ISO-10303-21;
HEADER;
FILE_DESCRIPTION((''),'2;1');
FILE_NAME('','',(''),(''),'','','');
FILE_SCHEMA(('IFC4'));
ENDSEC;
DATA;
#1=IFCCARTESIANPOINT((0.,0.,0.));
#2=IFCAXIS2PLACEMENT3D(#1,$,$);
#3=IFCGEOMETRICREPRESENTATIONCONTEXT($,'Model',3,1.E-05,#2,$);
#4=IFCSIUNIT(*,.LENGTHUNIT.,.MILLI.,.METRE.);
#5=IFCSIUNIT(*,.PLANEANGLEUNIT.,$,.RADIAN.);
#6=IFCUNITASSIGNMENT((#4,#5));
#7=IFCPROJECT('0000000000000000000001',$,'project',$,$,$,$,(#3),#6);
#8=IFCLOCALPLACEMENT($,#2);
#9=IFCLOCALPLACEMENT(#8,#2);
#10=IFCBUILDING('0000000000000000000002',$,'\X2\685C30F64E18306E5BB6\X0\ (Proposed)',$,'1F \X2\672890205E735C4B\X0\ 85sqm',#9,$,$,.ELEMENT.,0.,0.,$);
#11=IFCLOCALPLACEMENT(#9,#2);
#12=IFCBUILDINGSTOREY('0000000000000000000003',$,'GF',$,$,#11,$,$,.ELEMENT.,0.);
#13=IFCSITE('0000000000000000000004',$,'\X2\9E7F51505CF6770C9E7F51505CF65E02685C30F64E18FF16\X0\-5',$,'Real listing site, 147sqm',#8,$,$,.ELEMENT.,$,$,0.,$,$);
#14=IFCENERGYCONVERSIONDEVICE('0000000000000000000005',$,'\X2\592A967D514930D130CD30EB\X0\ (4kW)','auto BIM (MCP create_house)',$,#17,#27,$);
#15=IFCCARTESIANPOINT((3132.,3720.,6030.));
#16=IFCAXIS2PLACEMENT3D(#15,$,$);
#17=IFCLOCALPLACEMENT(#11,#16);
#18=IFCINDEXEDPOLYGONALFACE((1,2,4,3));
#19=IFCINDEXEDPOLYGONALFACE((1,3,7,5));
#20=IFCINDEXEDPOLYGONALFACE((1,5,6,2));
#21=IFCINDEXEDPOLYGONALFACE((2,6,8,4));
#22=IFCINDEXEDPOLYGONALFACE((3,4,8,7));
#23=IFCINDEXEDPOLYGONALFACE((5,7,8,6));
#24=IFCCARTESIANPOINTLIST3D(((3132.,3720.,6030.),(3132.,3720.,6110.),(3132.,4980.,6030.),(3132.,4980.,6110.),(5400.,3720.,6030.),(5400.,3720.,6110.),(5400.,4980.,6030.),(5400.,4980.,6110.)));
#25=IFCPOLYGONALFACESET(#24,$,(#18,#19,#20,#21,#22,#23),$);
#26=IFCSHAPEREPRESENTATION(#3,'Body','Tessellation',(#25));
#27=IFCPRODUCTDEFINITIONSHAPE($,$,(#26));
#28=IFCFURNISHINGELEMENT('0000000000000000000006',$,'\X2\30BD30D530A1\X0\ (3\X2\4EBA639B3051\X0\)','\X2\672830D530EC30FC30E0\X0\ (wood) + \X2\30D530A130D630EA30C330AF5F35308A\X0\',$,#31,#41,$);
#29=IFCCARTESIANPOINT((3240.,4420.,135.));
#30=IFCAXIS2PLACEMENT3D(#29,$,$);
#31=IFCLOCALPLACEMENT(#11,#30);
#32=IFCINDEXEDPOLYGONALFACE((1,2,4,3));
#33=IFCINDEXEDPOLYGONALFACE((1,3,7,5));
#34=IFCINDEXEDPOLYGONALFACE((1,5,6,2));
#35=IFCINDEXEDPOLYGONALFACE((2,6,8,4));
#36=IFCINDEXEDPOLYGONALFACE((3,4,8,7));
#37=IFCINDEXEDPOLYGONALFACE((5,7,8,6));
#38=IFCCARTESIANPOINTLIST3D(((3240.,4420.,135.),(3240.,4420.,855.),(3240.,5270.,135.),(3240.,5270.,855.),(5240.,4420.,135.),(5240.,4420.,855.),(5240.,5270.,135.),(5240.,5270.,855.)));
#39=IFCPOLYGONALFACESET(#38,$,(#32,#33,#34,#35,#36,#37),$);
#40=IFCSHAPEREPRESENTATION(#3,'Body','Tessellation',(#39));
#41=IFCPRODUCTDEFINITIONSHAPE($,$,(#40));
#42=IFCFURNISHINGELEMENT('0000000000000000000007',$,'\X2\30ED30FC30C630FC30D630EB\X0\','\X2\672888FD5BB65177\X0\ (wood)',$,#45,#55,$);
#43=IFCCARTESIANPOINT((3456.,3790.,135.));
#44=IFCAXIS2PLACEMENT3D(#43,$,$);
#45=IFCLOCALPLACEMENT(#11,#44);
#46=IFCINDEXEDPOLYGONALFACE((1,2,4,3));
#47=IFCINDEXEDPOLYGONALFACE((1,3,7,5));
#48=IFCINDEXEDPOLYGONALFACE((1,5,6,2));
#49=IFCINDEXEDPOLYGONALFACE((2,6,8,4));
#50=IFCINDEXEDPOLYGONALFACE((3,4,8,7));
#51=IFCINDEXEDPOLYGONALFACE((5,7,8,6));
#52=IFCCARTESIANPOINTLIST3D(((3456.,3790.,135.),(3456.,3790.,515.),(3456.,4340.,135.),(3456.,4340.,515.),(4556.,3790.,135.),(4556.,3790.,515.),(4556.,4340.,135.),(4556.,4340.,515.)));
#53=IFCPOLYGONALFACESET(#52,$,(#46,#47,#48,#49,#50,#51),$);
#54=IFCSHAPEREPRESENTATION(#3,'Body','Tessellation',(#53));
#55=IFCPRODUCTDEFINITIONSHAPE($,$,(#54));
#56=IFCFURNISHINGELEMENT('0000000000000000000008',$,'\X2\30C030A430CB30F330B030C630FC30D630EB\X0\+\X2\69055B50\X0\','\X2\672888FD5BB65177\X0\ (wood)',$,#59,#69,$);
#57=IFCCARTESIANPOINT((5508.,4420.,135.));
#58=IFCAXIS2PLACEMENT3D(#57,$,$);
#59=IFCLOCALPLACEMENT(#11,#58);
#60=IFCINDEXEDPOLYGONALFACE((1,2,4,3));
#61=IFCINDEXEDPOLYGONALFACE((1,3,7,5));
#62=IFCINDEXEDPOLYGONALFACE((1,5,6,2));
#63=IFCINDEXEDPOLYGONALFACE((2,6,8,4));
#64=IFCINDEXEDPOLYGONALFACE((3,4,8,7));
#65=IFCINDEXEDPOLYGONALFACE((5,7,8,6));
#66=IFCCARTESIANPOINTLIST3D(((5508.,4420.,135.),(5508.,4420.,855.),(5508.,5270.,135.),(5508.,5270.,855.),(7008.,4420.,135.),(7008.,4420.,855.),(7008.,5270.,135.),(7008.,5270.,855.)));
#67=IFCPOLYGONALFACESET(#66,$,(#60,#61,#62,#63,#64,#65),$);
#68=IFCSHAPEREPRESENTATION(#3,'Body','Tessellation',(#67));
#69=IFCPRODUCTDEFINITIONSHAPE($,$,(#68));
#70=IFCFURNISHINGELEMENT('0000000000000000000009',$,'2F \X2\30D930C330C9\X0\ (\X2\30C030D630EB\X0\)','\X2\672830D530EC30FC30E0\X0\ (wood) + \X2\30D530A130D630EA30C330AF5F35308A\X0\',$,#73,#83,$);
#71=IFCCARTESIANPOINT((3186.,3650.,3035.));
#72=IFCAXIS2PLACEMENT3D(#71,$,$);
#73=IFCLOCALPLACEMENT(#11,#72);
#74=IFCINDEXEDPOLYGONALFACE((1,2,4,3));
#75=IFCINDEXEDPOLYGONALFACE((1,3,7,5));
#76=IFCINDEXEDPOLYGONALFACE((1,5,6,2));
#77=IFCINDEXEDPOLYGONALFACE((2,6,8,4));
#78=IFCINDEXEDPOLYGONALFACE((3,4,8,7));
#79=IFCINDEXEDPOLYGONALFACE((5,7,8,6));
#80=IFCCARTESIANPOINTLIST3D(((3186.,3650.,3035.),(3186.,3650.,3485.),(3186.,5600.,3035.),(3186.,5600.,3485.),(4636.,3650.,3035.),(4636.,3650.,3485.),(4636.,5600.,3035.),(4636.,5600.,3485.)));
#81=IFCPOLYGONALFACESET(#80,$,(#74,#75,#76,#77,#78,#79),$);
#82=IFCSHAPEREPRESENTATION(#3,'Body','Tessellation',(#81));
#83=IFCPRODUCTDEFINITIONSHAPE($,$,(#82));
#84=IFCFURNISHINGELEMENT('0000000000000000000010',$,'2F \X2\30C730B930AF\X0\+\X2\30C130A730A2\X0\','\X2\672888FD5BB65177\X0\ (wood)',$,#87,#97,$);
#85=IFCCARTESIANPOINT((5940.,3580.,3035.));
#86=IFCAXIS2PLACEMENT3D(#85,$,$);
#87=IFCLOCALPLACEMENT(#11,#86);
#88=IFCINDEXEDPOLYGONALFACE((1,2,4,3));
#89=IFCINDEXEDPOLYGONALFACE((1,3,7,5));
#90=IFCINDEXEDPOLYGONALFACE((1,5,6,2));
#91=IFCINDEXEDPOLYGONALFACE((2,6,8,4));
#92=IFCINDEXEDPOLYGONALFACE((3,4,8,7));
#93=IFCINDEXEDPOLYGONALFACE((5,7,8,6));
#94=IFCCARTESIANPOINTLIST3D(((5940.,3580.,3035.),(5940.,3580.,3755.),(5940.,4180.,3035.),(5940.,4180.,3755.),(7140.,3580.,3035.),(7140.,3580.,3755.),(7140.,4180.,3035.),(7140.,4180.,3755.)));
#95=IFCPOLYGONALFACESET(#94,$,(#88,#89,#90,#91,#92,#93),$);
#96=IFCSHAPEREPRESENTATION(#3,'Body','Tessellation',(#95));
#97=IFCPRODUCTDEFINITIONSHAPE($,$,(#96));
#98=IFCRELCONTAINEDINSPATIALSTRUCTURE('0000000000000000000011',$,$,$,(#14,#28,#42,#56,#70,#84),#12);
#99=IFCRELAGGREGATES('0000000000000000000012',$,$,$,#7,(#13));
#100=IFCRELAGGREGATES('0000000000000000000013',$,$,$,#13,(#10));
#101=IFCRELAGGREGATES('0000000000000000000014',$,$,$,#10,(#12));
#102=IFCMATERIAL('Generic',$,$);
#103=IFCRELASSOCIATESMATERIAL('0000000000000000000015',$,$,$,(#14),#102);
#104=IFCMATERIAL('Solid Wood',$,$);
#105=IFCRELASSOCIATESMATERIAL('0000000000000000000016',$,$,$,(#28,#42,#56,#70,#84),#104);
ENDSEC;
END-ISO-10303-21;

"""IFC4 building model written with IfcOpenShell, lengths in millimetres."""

from ifc_helpers import new_model, si_unit, frame, frame_2d, origin, place, context, project, spatial, rectangle, extrude, material, element, save


model = new_model("IFC4")

# Units and contexts
model_context = context("Model", 3, precision=1e-05, world=origin())
ifc_project = project(units=[si_unit("LENGTHUNIT", "METRE", prefix="MILLI"), si_unit("PLANEANGLEUNIT", "RADIAN")], contexts=[model_context])

# Site, building, storey
site_placement = place(None, origin())
site = spatial("IfcSite", under=ifc_project, at=site_placement, Name="鹿児島県鹿児島市桜ヶ丘６-5", ObjectType="Real listing site, 147sqm", CompositionType="ELEMENT", RefElevation=0.0)
building_placement = place(site_placement, origin())
building = spatial("IfcBuilding", under=site, at=building_placement, Name="桜ヶ丘の家 (Proposed)", ObjectType="1F 木造平屋 85sqm", CompositionType="ELEMENT", ElevationOfRefHeight=0.0, ElevationOfTerrain=0.0)
storey_placement = place(building_placement, origin())
storey = spatial("IfcBuildingStorey", under=building, at=storey_placement, Name="GF", CompositionType="ELEMENT", Elevation=0.0)

# Shared definitions
ifc_material_1 = material(Name="Solid Wood")

# Shared definitions
ifc_material_2 = material(Name="Generic")

# Energy conversion device
energy_conversion_device_placement = place(storey_placement, frame((3132.0, 3720.0, 6030.0)))
element("IfcEnergyConversionDevice", 1, at=energy_conversion_device_placement, inside=storey, material=ifc_material_2, Name="太陽光パネル (4kW)", Description="auto BIM (MCP create_house)", context=model_context, shape_type="SweptSolid", body=[
    extrude(rectangle(XDim=2268.0, YDim=1260.0, at=frame_2d((1134.0, 630.0))), frame((3132.0, 3720.0, 6030.0)), (0.0, 0.0, 1.0), 80.0),
])

# Furnishing elements
furnishing_1_placement = place(storey_placement, frame((3240.0, 4420.0, 135.0)))
element("IfcFurnishingElement", 2, at=furnishing_1_placement, inside=storey, material=ifc_material_1, Name="ソファ (3人掛け)", Description="木フレーム (wood) + ファブリック張り", context=model_context, shape_type="SweptSolid", body=[
    extrude(rectangle(XDim=2000.0, YDim=850.0, at=frame_2d((1000.0, 425.0))), frame((3240.0, 4420.0, 135.0)), (0.0, 0.0, 1.0), 720.0),
])
furnishing_2_placement = place(storey_placement, frame((3456.0, 3790.0, 135.0)))
element("IfcFurnishingElement", 3, at=furnishing_2_placement, inside=storey, material=ifc_material_1, Name="ローテーブル", Description="木製家具 (wood)", context=model_context, shape_type="SweptSolid", body=[
    extrude(rectangle(XDim=1100.0, YDim=550.0, at=frame_2d((550.0, 275.0))), frame((3456.0, 3790.0, 135.0)), (0.0, 0.0, 1.0), 380.0),
])
furnishing_3_placement = place(storey_placement, frame((5508.0, 4420.0, 135.0)))
element("IfcFurnishingElement", 4, at=furnishing_3_placement, inside=storey, material=ifc_material_1, Name="ダイニングテーブル+椅子", Description="木製家具 (wood)", context=model_context, shape_type="SweptSolid", body=[
    extrude(rectangle(XDim=1500.0, YDim=850.0, at=frame_2d((750.0, 425.0))), frame((5508.0, 4420.0, 135.0)), (0.0, 0.0, 1.0), 720.0),
])
furnishing_4_placement = place(storey_placement, frame((3186.0, 3650.0, 3035.0)))
element("IfcFurnishingElement", 5, at=furnishing_4_placement, inside=storey, material=ifc_material_1, Name="2F ベッド (ダブル)", Description="木フレーム (wood) + ファブリック張り", context=model_context, shape_type="SweptSolid", body=[
    extrude(rectangle(XDim=1450.0, YDim=1950.0, at=frame_2d((725.0, 975.0))), frame((3186.0, 3650.0, 3035.0)), (0.0, 0.0, 1.0), 450.0),
])
furnishing_5_placement = place(storey_placement, frame((5940.0, 3580.0, 3035.0)))
element("IfcFurnishingElement", 6, at=furnishing_5_placement, inside=storey, material=ifc_material_1, Name="2F デスク+チェア", Description="木製家具 (wood)", context=model_context, shape_type="SweptSolid", body=[
    extrude(rectangle(XDim=1200.0, YDim=600.0, at=frame_2d((600.0, 300.0))), frame((5940.0, 3580.0, 3035.0)), (0.0, 0.0, 1.0), 720.0),
])

save(model, "model.ifc")
